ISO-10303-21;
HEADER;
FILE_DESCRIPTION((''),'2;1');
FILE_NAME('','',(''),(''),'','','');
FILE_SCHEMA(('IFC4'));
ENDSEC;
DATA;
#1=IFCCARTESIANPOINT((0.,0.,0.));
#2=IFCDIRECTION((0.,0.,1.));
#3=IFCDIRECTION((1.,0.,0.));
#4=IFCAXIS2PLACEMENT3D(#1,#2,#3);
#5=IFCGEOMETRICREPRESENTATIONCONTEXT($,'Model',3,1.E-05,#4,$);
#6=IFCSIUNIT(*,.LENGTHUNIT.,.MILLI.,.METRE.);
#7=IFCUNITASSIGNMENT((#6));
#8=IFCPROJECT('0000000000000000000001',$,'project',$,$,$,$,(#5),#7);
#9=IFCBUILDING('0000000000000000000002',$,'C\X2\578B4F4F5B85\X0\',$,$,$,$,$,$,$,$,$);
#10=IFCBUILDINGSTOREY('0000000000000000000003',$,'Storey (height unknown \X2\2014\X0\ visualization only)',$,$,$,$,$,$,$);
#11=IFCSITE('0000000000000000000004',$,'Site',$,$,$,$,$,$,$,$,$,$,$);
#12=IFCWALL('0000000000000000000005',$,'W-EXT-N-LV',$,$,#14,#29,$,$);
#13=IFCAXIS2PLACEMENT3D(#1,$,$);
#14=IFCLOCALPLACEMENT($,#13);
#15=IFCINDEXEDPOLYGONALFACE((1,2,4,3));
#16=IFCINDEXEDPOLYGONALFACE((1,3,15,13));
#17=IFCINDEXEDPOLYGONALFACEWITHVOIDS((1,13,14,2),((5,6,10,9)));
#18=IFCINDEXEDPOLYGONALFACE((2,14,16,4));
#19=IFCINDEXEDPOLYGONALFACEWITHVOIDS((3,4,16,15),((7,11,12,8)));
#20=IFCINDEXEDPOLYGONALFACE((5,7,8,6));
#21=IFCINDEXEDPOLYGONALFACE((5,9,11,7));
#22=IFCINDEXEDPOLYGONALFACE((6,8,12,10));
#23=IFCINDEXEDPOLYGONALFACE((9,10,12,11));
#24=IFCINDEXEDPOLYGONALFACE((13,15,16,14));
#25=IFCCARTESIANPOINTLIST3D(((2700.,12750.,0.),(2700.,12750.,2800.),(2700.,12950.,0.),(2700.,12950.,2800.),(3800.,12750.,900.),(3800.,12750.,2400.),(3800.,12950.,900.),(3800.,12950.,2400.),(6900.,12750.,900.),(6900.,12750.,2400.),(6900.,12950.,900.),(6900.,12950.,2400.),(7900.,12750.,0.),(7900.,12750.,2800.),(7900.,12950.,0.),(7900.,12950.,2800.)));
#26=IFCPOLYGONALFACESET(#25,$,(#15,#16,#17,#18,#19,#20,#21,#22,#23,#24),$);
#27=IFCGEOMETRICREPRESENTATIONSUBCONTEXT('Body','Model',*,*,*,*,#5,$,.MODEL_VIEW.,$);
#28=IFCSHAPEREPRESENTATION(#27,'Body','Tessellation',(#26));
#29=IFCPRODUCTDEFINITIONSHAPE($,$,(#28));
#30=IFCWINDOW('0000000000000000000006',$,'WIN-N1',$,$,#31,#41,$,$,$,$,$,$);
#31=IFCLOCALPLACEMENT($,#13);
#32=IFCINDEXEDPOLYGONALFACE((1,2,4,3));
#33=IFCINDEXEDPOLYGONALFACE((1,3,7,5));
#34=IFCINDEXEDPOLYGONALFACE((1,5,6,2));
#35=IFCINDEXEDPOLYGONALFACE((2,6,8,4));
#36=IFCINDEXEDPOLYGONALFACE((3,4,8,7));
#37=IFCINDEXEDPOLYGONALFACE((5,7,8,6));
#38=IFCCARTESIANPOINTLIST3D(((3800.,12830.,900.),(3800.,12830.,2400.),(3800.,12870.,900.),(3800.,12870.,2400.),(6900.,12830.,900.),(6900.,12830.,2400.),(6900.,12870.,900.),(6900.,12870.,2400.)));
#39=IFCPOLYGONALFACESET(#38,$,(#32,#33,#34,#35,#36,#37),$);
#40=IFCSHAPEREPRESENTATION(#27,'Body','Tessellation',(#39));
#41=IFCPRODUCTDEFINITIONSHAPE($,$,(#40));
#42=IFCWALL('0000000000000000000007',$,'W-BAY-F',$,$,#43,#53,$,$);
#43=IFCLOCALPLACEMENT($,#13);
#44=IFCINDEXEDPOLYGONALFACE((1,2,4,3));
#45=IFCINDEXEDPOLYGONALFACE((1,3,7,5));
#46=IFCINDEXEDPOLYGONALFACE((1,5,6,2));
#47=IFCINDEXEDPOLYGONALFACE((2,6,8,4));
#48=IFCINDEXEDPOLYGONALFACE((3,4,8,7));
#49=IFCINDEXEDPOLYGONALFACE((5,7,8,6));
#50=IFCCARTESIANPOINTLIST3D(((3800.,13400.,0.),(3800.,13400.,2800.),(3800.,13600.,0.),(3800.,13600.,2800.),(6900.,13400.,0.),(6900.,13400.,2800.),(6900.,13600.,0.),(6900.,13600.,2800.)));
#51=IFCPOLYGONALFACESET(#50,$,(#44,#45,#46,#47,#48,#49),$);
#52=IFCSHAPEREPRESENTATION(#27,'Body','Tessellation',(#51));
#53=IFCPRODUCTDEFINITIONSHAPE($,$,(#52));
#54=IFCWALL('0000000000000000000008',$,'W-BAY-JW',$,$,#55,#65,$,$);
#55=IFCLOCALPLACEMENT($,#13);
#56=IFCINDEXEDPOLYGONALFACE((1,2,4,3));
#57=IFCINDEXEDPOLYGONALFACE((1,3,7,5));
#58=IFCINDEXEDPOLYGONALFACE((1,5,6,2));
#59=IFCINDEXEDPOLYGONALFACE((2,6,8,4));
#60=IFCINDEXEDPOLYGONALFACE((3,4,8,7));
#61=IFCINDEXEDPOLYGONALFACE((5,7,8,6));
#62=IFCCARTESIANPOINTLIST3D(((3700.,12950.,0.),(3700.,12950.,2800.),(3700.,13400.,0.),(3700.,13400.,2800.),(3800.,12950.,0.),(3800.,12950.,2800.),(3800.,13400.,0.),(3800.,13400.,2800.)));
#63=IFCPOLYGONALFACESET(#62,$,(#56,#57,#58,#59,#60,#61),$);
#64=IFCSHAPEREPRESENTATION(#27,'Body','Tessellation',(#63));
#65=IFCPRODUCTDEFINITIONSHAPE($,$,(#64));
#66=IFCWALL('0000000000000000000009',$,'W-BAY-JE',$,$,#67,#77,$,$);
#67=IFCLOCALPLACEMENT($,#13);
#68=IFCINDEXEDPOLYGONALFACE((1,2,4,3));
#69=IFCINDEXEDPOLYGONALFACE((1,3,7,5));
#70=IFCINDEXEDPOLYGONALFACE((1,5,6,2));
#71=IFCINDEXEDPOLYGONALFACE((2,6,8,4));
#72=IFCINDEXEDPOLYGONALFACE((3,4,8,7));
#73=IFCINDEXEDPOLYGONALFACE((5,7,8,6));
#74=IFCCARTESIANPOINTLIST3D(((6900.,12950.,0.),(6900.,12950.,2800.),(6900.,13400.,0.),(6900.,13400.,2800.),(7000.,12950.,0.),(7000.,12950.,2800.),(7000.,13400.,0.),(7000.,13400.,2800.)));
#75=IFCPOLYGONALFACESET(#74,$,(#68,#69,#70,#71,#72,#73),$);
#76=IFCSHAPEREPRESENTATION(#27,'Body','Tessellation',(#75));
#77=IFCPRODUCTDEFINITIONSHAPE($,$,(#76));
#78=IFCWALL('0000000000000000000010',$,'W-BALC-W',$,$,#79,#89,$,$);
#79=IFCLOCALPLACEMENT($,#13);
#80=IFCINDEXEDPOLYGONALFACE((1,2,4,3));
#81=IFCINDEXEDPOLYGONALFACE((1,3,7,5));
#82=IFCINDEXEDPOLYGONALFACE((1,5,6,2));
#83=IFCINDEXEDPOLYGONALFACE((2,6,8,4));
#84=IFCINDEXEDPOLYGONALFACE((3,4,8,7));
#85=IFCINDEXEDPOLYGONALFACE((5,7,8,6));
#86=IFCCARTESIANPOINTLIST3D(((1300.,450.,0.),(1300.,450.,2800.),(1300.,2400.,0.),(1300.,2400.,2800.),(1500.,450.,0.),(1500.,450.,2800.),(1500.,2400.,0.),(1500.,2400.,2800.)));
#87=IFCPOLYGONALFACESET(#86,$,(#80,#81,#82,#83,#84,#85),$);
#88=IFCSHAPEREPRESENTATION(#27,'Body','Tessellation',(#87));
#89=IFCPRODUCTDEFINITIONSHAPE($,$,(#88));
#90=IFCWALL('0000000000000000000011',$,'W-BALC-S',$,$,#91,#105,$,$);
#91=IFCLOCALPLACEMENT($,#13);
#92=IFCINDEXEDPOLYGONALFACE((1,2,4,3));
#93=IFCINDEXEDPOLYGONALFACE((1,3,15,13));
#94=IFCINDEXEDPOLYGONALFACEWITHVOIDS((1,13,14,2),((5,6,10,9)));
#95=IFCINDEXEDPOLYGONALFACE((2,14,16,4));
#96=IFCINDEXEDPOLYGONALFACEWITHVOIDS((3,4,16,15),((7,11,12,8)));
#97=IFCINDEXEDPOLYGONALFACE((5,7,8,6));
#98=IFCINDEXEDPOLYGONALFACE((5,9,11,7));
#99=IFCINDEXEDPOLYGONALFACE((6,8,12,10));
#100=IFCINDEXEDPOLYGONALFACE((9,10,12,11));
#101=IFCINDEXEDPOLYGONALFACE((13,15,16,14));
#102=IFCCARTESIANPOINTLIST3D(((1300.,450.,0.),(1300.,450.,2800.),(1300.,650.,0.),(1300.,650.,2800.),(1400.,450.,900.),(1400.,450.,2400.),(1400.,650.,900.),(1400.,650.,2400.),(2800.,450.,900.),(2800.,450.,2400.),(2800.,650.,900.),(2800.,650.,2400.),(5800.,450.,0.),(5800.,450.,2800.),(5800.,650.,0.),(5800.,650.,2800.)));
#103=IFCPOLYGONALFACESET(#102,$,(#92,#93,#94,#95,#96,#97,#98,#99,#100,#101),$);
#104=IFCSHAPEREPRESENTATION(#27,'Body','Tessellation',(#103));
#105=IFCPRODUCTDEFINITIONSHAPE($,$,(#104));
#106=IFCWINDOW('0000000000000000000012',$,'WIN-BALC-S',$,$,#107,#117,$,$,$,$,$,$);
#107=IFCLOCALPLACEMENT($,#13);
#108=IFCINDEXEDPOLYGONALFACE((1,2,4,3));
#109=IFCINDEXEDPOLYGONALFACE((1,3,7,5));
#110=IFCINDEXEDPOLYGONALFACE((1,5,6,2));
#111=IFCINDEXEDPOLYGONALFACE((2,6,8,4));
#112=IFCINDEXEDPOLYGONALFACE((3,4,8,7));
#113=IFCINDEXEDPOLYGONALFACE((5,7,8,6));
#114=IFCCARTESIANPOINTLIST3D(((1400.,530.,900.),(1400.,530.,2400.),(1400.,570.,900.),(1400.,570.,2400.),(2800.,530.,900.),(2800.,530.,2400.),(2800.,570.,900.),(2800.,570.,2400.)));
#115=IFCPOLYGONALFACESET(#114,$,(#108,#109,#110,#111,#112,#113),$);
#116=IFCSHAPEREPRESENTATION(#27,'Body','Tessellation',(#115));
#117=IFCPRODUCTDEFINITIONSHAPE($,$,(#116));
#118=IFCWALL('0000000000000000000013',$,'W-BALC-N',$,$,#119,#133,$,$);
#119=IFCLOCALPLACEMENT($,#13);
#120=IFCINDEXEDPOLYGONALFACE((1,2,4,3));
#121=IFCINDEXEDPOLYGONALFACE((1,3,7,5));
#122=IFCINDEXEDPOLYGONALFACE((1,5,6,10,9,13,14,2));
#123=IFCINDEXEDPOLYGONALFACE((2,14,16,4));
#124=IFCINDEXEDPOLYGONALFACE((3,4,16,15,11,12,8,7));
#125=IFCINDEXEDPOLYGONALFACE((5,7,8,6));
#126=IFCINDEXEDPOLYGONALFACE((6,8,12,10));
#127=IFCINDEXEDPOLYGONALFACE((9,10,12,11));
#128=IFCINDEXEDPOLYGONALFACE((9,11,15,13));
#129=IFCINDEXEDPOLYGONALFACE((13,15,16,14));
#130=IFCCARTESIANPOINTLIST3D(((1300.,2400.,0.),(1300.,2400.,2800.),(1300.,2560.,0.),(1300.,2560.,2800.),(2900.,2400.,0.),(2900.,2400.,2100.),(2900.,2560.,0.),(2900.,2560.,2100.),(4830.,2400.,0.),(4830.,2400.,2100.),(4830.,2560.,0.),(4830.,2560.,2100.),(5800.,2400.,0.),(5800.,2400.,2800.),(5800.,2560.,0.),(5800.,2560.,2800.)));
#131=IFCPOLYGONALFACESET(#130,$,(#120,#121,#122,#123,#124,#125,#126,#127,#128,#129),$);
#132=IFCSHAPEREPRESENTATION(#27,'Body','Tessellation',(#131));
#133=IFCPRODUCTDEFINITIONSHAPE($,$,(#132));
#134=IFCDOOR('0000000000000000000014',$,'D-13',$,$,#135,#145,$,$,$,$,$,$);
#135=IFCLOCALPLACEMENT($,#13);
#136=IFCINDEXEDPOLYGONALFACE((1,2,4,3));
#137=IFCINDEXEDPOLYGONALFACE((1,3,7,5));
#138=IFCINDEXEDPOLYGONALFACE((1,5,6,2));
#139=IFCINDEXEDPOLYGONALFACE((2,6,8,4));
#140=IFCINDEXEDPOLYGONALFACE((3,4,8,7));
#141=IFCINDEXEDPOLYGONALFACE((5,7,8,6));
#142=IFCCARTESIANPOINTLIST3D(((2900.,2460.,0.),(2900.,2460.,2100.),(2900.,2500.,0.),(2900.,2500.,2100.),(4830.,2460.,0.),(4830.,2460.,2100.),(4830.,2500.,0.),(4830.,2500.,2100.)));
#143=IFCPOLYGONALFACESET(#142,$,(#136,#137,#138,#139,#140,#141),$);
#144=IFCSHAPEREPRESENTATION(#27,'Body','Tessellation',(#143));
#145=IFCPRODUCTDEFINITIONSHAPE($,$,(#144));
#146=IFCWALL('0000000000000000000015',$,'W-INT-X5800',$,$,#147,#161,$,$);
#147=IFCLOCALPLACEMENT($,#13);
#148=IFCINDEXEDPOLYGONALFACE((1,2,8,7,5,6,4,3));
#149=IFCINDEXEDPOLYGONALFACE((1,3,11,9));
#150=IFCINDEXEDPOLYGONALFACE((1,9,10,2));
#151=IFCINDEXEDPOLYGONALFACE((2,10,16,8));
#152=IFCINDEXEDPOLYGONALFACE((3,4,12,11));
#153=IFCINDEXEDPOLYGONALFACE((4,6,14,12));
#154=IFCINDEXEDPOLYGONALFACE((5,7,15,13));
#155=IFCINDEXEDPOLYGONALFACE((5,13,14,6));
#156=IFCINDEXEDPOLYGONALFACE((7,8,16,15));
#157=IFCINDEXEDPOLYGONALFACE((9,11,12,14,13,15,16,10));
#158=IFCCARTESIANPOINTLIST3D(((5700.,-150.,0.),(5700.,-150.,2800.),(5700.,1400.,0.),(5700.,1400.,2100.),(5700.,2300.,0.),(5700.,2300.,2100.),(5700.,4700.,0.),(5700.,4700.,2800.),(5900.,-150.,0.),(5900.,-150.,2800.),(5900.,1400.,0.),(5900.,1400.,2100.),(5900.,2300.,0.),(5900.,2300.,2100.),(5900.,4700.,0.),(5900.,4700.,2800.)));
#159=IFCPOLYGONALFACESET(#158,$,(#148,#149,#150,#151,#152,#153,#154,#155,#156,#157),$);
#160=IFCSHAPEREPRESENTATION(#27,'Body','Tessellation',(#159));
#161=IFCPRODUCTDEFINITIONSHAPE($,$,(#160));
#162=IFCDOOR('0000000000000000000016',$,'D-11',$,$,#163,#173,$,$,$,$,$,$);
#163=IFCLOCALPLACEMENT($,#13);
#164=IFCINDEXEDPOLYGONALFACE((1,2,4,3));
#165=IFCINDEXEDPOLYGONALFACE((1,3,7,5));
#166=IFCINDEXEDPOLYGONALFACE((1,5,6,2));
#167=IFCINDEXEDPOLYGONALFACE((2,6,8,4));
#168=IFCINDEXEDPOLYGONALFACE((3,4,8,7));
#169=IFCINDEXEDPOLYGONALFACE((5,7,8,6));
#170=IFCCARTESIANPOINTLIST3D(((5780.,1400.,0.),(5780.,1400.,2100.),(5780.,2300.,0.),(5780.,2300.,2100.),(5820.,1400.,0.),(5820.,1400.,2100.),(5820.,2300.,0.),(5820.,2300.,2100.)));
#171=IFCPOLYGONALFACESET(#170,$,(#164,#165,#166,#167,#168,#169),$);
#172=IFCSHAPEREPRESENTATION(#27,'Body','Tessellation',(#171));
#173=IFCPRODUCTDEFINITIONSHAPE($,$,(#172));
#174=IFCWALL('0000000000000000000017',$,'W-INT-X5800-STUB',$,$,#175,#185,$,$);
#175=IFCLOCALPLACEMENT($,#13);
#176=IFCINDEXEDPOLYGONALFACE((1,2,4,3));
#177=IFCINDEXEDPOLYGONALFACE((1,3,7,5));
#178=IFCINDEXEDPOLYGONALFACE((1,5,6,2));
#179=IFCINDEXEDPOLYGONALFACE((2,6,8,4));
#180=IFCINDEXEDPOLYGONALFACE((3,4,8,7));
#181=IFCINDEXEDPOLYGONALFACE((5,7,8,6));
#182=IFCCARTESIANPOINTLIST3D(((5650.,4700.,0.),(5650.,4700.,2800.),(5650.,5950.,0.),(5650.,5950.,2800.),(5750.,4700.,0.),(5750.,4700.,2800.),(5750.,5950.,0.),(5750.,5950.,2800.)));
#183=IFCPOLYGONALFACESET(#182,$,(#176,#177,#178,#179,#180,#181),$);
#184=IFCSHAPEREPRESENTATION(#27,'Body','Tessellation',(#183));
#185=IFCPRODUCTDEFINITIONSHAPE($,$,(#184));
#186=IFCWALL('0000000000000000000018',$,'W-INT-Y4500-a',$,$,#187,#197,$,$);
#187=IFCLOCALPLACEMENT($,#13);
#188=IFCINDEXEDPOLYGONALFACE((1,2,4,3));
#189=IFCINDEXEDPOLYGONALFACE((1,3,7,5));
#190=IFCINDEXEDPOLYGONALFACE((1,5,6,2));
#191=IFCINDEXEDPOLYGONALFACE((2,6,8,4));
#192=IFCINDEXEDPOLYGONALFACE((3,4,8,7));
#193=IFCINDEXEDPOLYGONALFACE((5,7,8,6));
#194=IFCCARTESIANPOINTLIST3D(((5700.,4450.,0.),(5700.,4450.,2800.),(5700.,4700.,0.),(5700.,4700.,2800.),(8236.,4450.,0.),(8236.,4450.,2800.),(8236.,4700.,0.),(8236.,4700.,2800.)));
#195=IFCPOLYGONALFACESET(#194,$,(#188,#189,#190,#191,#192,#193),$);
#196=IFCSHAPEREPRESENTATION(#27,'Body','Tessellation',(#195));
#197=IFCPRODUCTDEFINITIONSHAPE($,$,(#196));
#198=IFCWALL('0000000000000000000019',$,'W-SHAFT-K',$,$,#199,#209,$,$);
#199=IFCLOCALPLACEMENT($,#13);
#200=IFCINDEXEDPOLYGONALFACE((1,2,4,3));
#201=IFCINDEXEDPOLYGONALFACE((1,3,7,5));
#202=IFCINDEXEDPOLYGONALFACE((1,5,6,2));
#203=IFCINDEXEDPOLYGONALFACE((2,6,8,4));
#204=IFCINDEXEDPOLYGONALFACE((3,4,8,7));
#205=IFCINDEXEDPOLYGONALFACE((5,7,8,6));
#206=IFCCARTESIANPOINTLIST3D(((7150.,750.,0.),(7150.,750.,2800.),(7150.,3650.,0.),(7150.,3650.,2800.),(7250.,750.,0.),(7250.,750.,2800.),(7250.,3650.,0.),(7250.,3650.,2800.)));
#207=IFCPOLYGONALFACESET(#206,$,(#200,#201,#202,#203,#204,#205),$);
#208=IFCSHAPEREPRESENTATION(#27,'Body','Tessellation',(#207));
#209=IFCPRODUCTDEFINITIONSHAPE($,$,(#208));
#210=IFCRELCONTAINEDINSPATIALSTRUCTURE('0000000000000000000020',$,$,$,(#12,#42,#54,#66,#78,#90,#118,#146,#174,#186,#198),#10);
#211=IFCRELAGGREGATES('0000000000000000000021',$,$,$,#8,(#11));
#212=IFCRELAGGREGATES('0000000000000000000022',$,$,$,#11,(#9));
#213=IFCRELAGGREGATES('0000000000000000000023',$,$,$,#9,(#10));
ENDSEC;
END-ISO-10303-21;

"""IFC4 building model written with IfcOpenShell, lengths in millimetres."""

from ifc_helpers import new_model, si_unit, frame, frame_2d, origin_with_axes, place, context, subcontext, project, spatial, rectangle, extrude, element, fill, save


model = new_model("IFC4")

# Units and contexts
model_context = context("Model", 3, precision=1e-05, world=origin_with_axes())
body_context = subcontext(model_context, "Body", "Model", "MODEL_VIEW")
ifc_project = project(units=[si_unit("LENGTHUNIT", "METRE", prefix="MILLI")], contexts=[model_context])

# Site, building, storey
site = spatial("IfcSite", under=ifc_project, Name="Site")
building = spatial("IfcBuilding", under=site, Name="C型住宅")
storey = spatial("IfcBuildingStorey", under=building, Name="Storey (height unknown — visualization only)")

# Wall, opening, window
wall_1_placement = place(None, frame((2700.0, 12750.0, 0.0), z_axis=(0.0, 0.0, 1.0), x_axis=(1.0, 0.0, 0.0)))
wall_1 = element("IfcWall", 1, at=wall_1_placement, inside=storey, Name="W-EXT-N-LV", context=body_context, shape_type="SweptSolid", body=[
    extrude(rectangle(XDim=5200.0, YDim=200.0, at=frame_2d((2600.0, 100.0))), origin_with_axes(), (0.0, 0.0, 1.0), 2800.0),
])
opening_1_placement = place(wall_1_placement, frame((1100.0, 0.0, 900.0)))
opening_1 = element("IfcOpeningElement", 2, at=opening_1_placement, cuts=wall_1, context=body_context, shape_type="SweptSolid", body=[
    extrude(rectangle(XDim=3100.0, YDim=200.0, at=frame_2d((1550.0, 100.0))), origin_with_axes(), (0.0, 0.0, 1.0), 1500.0),
])
window_1_placement = place(wall_1_placement, frame((1100.0, 80.0, 900.0)))
window_1 = element("IfcWindow", 3, at=window_1_placement, Name="WIN-N1", context=body_context, shape_type="SweptSolid", body=[
    extrude(rectangle(XDim=3100.0, YDim=40.0, at=frame_2d((1550.0, 20.0))), origin_with_axes(), (0.0, 0.0, 1.0), 1500.0),
])
fill(opening_1, window_1)

# Walls
wall_2_placement = place(None, frame((3800.0, 13400.0, 0.0), z_axis=(0.0, 0.0, 1.0), x_axis=(1.0, 0.0, 0.0)))
element("IfcWall", 4, at=wall_2_placement, inside=storey, Name="W-BAY-F", context=body_context, shape_type="SweptSolid", body=[
    extrude(rectangle(XDim=3100.0, YDim=200.0, at=frame_2d((1550.0, 100.0))), origin_with_axes(), (0.0, 0.0, 1.0), 2800.0),
])
for number, where, z_axis, x_axis, name in (
    (5, (3700.0, 12950.0, 0.0), (0.0, 0.0, 1.0), (1.0, 0.0, 0.0), "W-BAY-JW"),
    (6, (6900.0, 12950.0, 0.0), (0.0, 0.0, 1.0), (1.0, 0.0, 0.0), "W-BAY-JE"),
):
    element("IfcWall", number, at=place(None, frame(where, z_axis=z_axis, x_axis=x_axis)), inside=storey, Name=name, context=body_context, shape_type="SweptSolid", body=[
        extrude(rectangle(XDim=100.0, YDim=450.0, at=frame_2d((50.0, 225.0))), origin_with_axes(), (0.0, 0.0, 1.0), 2800.0),
    ])
wall_3_placement = place(None, frame((1300.0, 450.0, 0.0), z_axis=(0.0, 0.0, 1.0), x_axis=(1.0, 0.0, 0.0)))
element("IfcWall", 7, at=wall_3_placement, inside=storey, Name="W-BALC-W", context=body_context, shape_type="SweptSolid", body=[
    extrude(rectangle(XDim=200.0, YDim=1950.0, at=frame_2d((100.0, 975.0))), origin_with_axes(), (0.0, 0.0, 1.0), 2800.0),
])

# Wall, opening, window
wall_4_placement = place(None, frame((1300.0, 450.0, 0.0), z_axis=(0.0, 0.0, 1.0), x_axis=(1.0, 0.0, 0.0)))
wall_4 = element("IfcWall", 8, at=wall_4_placement, inside=storey, Name="W-BALC-S", context=body_context, shape_type="SweptSolid", body=[
    extrude(rectangle(XDim=4500.0, YDim=200.0, at=frame_2d((2250.0, 100.0))), origin_with_axes(), (0.0, 0.0, 1.0), 2800.0),
])
opening_2_placement = place(wall_4_placement, frame((100.0, 0.0, 900.0)))
opening_2 = element("IfcOpeningElement", 9, at=opening_2_placement, cuts=wall_4, context=body_context, shape_type="SweptSolid", body=[
    extrude(rectangle(XDim=1400.0, YDim=200.0, at=frame_2d((700.0, 100.0))), origin_with_axes(), (0.0, 0.0, 1.0), 1500.0),
])
window_2_placement = place(wall_4_placement, frame((100.0, 80.0, 900.0)))
window_2 = element("IfcWindow", 10, at=window_2_placement, Name="WIN-BALC-S", context=body_context, shape_type="SweptSolid", body=[
    extrude(rectangle(XDim=1400.0, YDim=40.0, at=frame_2d((700.0, 20.0))), origin_with_axes(), (0.0, 0.0, 1.0), 1500.0),
])
fill(opening_2, window_2)

# Walls, openings, doors
wall_5_placement = place(None, frame((1300.0, 2400.0, 0.0), z_axis=(0.0, 0.0, 1.0), x_axis=(1.0, 0.0, 0.0)))
wall_5 = element("IfcWall", 11, at=wall_5_placement, inside=storey, Name="W-BALC-N", context=body_context, shape_type="SweptSolid", body=[
    extrude(rectangle(XDim=4500.0, YDim=160.0, at=frame_2d((2250.0, 80.0))), origin_with_axes(), (0.0, 0.0, 1.0), 2800.0),
])
opening_3_placement = place(wall_5_placement, frame((1600.0, 0.0, 0.0)))
opening_3 = element("IfcOpeningElement", 12, at=opening_3_placement, cuts=wall_5, context=body_context, shape_type="SweptSolid", body=[
    extrude(rectangle(XDim=1930.0, YDim=160.0, at=frame_2d((965.0, 80.0))), origin_with_axes(), (0.0, 0.0, 1.0), 2100.0),
])
door_1_placement = place(wall_5_placement, frame((1600.0, 60.0, 0.0)))
door_1 = element("IfcDoor", 13, at=door_1_placement, Name="D-13", context=body_context, shape_type="SweptSolid", body=[
    extrude(rectangle(XDim=1930.0, YDim=40.0, at=frame_2d((965.0, 20.0))), origin_with_axes(), (0.0, 0.0, 1.0), 2100.0),
])
fill(opening_3, door_1)
wall_6_placement = place(None, frame((5700.0, -150.0, 0.0), z_axis=(0.0, 0.0, 1.0), x_axis=(1.0, 0.0, 0.0)))
wall_6 = element("IfcWall", 14, at=wall_6_placement, inside=storey, Name="W-INT-X5800", context=body_context, shape_type="SweptSolid", body=[
    extrude(rectangle(XDim=200.0, YDim=4850.0, at=frame_2d((100.0, 2425.0))), origin_with_axes(), (0.0, 0.0, 1.0), 2800.0),
])
opening_4_placement = place(wall_6_placement, frame((0.0, 1550.0, 0.0)))
opening_4 = element("IfcOpeningElement", 15, at=opening_4_placement, cuts=wall_6, context=body_context, shape_type="SweptSolid", body=[
    extrude(rectangle(XDim=200.0, YDim=900.0, at=frame_2d((100.0, 450.0))), origin_with_axes(), (0.0, 0.0, 1.0), 2100.0),
])
door_2_placement = place(wall_6_placement, frame((80.0, 1550.0, 0.0)))
door_2 = element("IfcDoor", 16, at=door_2_placement, Name="D-11", context=body_context, shape_type="SweptSolid", body=[
    extrude(rectangle(XDim=40.0, YDim=900.0, at=frame_2d((20.0, 450.0))), origin_with_axes(), (0.0, 0.0, 1.0), 2100.0),
])
fill(opening_4, door_2)

# Walls
wall_7_placement = place(None, frame((5650.0, 4700.0, 0.0), z_axis=(0.0, 0.0, 1.0), x_axis=(1.0, 0.0, 0.0)))
element("IfcWall", 17, at=wall_7_placement, inside=storey, Name="W-INT-X5800-STUB", context=body_context, shape_type="SweptSolid", body=[
    extrude(rectangle(XDim=100.0, YDim=1250.0, at=frame_2d((50.0, 625.0))), origin_with_axes(), (0.0, 0.0, 1.0), 2800.0),
])
wall_8_placement = place(None, frame((5700.0, 4450.0, 0.0), z_axis=(0.0, 0.0, 1.0), x_axis=(1.0, 0.0, 0.0)))
element("IfcWall", 18, at=wall_8_placement, inside=storey, Name="W-INT-Y4500-a", context=body_context, shape_type="SweptSolid", body=[
    extrude(rectangle(XDim=2536.0, YDim=250.0, at=frame_2d((1268.0, 125.0))), origin_with_axes(), (0.0, 0.0, 1.0), 2800.0),
])
wall_9_placement = place(None, frame((7150.0, 750.0, 0.0), z_axis=(0.0, 0.0, 1.0), x_axis=(1.0, 0.0, 0.0)))
element("IfcWall", 19, at=wall_9_placement, inside=storey, Name="W-SHAFT-K", context=body_context, shape_type="SweptSolid", body=[
    extrude(rectangle(XDim=100.0, YDim=2900.0, at=frame_2d((50.0, 1450.0))), origin_with_axes(), (0.0, 0.0, 1.0), 2800.0),
])

save(model, "model.ifc")
